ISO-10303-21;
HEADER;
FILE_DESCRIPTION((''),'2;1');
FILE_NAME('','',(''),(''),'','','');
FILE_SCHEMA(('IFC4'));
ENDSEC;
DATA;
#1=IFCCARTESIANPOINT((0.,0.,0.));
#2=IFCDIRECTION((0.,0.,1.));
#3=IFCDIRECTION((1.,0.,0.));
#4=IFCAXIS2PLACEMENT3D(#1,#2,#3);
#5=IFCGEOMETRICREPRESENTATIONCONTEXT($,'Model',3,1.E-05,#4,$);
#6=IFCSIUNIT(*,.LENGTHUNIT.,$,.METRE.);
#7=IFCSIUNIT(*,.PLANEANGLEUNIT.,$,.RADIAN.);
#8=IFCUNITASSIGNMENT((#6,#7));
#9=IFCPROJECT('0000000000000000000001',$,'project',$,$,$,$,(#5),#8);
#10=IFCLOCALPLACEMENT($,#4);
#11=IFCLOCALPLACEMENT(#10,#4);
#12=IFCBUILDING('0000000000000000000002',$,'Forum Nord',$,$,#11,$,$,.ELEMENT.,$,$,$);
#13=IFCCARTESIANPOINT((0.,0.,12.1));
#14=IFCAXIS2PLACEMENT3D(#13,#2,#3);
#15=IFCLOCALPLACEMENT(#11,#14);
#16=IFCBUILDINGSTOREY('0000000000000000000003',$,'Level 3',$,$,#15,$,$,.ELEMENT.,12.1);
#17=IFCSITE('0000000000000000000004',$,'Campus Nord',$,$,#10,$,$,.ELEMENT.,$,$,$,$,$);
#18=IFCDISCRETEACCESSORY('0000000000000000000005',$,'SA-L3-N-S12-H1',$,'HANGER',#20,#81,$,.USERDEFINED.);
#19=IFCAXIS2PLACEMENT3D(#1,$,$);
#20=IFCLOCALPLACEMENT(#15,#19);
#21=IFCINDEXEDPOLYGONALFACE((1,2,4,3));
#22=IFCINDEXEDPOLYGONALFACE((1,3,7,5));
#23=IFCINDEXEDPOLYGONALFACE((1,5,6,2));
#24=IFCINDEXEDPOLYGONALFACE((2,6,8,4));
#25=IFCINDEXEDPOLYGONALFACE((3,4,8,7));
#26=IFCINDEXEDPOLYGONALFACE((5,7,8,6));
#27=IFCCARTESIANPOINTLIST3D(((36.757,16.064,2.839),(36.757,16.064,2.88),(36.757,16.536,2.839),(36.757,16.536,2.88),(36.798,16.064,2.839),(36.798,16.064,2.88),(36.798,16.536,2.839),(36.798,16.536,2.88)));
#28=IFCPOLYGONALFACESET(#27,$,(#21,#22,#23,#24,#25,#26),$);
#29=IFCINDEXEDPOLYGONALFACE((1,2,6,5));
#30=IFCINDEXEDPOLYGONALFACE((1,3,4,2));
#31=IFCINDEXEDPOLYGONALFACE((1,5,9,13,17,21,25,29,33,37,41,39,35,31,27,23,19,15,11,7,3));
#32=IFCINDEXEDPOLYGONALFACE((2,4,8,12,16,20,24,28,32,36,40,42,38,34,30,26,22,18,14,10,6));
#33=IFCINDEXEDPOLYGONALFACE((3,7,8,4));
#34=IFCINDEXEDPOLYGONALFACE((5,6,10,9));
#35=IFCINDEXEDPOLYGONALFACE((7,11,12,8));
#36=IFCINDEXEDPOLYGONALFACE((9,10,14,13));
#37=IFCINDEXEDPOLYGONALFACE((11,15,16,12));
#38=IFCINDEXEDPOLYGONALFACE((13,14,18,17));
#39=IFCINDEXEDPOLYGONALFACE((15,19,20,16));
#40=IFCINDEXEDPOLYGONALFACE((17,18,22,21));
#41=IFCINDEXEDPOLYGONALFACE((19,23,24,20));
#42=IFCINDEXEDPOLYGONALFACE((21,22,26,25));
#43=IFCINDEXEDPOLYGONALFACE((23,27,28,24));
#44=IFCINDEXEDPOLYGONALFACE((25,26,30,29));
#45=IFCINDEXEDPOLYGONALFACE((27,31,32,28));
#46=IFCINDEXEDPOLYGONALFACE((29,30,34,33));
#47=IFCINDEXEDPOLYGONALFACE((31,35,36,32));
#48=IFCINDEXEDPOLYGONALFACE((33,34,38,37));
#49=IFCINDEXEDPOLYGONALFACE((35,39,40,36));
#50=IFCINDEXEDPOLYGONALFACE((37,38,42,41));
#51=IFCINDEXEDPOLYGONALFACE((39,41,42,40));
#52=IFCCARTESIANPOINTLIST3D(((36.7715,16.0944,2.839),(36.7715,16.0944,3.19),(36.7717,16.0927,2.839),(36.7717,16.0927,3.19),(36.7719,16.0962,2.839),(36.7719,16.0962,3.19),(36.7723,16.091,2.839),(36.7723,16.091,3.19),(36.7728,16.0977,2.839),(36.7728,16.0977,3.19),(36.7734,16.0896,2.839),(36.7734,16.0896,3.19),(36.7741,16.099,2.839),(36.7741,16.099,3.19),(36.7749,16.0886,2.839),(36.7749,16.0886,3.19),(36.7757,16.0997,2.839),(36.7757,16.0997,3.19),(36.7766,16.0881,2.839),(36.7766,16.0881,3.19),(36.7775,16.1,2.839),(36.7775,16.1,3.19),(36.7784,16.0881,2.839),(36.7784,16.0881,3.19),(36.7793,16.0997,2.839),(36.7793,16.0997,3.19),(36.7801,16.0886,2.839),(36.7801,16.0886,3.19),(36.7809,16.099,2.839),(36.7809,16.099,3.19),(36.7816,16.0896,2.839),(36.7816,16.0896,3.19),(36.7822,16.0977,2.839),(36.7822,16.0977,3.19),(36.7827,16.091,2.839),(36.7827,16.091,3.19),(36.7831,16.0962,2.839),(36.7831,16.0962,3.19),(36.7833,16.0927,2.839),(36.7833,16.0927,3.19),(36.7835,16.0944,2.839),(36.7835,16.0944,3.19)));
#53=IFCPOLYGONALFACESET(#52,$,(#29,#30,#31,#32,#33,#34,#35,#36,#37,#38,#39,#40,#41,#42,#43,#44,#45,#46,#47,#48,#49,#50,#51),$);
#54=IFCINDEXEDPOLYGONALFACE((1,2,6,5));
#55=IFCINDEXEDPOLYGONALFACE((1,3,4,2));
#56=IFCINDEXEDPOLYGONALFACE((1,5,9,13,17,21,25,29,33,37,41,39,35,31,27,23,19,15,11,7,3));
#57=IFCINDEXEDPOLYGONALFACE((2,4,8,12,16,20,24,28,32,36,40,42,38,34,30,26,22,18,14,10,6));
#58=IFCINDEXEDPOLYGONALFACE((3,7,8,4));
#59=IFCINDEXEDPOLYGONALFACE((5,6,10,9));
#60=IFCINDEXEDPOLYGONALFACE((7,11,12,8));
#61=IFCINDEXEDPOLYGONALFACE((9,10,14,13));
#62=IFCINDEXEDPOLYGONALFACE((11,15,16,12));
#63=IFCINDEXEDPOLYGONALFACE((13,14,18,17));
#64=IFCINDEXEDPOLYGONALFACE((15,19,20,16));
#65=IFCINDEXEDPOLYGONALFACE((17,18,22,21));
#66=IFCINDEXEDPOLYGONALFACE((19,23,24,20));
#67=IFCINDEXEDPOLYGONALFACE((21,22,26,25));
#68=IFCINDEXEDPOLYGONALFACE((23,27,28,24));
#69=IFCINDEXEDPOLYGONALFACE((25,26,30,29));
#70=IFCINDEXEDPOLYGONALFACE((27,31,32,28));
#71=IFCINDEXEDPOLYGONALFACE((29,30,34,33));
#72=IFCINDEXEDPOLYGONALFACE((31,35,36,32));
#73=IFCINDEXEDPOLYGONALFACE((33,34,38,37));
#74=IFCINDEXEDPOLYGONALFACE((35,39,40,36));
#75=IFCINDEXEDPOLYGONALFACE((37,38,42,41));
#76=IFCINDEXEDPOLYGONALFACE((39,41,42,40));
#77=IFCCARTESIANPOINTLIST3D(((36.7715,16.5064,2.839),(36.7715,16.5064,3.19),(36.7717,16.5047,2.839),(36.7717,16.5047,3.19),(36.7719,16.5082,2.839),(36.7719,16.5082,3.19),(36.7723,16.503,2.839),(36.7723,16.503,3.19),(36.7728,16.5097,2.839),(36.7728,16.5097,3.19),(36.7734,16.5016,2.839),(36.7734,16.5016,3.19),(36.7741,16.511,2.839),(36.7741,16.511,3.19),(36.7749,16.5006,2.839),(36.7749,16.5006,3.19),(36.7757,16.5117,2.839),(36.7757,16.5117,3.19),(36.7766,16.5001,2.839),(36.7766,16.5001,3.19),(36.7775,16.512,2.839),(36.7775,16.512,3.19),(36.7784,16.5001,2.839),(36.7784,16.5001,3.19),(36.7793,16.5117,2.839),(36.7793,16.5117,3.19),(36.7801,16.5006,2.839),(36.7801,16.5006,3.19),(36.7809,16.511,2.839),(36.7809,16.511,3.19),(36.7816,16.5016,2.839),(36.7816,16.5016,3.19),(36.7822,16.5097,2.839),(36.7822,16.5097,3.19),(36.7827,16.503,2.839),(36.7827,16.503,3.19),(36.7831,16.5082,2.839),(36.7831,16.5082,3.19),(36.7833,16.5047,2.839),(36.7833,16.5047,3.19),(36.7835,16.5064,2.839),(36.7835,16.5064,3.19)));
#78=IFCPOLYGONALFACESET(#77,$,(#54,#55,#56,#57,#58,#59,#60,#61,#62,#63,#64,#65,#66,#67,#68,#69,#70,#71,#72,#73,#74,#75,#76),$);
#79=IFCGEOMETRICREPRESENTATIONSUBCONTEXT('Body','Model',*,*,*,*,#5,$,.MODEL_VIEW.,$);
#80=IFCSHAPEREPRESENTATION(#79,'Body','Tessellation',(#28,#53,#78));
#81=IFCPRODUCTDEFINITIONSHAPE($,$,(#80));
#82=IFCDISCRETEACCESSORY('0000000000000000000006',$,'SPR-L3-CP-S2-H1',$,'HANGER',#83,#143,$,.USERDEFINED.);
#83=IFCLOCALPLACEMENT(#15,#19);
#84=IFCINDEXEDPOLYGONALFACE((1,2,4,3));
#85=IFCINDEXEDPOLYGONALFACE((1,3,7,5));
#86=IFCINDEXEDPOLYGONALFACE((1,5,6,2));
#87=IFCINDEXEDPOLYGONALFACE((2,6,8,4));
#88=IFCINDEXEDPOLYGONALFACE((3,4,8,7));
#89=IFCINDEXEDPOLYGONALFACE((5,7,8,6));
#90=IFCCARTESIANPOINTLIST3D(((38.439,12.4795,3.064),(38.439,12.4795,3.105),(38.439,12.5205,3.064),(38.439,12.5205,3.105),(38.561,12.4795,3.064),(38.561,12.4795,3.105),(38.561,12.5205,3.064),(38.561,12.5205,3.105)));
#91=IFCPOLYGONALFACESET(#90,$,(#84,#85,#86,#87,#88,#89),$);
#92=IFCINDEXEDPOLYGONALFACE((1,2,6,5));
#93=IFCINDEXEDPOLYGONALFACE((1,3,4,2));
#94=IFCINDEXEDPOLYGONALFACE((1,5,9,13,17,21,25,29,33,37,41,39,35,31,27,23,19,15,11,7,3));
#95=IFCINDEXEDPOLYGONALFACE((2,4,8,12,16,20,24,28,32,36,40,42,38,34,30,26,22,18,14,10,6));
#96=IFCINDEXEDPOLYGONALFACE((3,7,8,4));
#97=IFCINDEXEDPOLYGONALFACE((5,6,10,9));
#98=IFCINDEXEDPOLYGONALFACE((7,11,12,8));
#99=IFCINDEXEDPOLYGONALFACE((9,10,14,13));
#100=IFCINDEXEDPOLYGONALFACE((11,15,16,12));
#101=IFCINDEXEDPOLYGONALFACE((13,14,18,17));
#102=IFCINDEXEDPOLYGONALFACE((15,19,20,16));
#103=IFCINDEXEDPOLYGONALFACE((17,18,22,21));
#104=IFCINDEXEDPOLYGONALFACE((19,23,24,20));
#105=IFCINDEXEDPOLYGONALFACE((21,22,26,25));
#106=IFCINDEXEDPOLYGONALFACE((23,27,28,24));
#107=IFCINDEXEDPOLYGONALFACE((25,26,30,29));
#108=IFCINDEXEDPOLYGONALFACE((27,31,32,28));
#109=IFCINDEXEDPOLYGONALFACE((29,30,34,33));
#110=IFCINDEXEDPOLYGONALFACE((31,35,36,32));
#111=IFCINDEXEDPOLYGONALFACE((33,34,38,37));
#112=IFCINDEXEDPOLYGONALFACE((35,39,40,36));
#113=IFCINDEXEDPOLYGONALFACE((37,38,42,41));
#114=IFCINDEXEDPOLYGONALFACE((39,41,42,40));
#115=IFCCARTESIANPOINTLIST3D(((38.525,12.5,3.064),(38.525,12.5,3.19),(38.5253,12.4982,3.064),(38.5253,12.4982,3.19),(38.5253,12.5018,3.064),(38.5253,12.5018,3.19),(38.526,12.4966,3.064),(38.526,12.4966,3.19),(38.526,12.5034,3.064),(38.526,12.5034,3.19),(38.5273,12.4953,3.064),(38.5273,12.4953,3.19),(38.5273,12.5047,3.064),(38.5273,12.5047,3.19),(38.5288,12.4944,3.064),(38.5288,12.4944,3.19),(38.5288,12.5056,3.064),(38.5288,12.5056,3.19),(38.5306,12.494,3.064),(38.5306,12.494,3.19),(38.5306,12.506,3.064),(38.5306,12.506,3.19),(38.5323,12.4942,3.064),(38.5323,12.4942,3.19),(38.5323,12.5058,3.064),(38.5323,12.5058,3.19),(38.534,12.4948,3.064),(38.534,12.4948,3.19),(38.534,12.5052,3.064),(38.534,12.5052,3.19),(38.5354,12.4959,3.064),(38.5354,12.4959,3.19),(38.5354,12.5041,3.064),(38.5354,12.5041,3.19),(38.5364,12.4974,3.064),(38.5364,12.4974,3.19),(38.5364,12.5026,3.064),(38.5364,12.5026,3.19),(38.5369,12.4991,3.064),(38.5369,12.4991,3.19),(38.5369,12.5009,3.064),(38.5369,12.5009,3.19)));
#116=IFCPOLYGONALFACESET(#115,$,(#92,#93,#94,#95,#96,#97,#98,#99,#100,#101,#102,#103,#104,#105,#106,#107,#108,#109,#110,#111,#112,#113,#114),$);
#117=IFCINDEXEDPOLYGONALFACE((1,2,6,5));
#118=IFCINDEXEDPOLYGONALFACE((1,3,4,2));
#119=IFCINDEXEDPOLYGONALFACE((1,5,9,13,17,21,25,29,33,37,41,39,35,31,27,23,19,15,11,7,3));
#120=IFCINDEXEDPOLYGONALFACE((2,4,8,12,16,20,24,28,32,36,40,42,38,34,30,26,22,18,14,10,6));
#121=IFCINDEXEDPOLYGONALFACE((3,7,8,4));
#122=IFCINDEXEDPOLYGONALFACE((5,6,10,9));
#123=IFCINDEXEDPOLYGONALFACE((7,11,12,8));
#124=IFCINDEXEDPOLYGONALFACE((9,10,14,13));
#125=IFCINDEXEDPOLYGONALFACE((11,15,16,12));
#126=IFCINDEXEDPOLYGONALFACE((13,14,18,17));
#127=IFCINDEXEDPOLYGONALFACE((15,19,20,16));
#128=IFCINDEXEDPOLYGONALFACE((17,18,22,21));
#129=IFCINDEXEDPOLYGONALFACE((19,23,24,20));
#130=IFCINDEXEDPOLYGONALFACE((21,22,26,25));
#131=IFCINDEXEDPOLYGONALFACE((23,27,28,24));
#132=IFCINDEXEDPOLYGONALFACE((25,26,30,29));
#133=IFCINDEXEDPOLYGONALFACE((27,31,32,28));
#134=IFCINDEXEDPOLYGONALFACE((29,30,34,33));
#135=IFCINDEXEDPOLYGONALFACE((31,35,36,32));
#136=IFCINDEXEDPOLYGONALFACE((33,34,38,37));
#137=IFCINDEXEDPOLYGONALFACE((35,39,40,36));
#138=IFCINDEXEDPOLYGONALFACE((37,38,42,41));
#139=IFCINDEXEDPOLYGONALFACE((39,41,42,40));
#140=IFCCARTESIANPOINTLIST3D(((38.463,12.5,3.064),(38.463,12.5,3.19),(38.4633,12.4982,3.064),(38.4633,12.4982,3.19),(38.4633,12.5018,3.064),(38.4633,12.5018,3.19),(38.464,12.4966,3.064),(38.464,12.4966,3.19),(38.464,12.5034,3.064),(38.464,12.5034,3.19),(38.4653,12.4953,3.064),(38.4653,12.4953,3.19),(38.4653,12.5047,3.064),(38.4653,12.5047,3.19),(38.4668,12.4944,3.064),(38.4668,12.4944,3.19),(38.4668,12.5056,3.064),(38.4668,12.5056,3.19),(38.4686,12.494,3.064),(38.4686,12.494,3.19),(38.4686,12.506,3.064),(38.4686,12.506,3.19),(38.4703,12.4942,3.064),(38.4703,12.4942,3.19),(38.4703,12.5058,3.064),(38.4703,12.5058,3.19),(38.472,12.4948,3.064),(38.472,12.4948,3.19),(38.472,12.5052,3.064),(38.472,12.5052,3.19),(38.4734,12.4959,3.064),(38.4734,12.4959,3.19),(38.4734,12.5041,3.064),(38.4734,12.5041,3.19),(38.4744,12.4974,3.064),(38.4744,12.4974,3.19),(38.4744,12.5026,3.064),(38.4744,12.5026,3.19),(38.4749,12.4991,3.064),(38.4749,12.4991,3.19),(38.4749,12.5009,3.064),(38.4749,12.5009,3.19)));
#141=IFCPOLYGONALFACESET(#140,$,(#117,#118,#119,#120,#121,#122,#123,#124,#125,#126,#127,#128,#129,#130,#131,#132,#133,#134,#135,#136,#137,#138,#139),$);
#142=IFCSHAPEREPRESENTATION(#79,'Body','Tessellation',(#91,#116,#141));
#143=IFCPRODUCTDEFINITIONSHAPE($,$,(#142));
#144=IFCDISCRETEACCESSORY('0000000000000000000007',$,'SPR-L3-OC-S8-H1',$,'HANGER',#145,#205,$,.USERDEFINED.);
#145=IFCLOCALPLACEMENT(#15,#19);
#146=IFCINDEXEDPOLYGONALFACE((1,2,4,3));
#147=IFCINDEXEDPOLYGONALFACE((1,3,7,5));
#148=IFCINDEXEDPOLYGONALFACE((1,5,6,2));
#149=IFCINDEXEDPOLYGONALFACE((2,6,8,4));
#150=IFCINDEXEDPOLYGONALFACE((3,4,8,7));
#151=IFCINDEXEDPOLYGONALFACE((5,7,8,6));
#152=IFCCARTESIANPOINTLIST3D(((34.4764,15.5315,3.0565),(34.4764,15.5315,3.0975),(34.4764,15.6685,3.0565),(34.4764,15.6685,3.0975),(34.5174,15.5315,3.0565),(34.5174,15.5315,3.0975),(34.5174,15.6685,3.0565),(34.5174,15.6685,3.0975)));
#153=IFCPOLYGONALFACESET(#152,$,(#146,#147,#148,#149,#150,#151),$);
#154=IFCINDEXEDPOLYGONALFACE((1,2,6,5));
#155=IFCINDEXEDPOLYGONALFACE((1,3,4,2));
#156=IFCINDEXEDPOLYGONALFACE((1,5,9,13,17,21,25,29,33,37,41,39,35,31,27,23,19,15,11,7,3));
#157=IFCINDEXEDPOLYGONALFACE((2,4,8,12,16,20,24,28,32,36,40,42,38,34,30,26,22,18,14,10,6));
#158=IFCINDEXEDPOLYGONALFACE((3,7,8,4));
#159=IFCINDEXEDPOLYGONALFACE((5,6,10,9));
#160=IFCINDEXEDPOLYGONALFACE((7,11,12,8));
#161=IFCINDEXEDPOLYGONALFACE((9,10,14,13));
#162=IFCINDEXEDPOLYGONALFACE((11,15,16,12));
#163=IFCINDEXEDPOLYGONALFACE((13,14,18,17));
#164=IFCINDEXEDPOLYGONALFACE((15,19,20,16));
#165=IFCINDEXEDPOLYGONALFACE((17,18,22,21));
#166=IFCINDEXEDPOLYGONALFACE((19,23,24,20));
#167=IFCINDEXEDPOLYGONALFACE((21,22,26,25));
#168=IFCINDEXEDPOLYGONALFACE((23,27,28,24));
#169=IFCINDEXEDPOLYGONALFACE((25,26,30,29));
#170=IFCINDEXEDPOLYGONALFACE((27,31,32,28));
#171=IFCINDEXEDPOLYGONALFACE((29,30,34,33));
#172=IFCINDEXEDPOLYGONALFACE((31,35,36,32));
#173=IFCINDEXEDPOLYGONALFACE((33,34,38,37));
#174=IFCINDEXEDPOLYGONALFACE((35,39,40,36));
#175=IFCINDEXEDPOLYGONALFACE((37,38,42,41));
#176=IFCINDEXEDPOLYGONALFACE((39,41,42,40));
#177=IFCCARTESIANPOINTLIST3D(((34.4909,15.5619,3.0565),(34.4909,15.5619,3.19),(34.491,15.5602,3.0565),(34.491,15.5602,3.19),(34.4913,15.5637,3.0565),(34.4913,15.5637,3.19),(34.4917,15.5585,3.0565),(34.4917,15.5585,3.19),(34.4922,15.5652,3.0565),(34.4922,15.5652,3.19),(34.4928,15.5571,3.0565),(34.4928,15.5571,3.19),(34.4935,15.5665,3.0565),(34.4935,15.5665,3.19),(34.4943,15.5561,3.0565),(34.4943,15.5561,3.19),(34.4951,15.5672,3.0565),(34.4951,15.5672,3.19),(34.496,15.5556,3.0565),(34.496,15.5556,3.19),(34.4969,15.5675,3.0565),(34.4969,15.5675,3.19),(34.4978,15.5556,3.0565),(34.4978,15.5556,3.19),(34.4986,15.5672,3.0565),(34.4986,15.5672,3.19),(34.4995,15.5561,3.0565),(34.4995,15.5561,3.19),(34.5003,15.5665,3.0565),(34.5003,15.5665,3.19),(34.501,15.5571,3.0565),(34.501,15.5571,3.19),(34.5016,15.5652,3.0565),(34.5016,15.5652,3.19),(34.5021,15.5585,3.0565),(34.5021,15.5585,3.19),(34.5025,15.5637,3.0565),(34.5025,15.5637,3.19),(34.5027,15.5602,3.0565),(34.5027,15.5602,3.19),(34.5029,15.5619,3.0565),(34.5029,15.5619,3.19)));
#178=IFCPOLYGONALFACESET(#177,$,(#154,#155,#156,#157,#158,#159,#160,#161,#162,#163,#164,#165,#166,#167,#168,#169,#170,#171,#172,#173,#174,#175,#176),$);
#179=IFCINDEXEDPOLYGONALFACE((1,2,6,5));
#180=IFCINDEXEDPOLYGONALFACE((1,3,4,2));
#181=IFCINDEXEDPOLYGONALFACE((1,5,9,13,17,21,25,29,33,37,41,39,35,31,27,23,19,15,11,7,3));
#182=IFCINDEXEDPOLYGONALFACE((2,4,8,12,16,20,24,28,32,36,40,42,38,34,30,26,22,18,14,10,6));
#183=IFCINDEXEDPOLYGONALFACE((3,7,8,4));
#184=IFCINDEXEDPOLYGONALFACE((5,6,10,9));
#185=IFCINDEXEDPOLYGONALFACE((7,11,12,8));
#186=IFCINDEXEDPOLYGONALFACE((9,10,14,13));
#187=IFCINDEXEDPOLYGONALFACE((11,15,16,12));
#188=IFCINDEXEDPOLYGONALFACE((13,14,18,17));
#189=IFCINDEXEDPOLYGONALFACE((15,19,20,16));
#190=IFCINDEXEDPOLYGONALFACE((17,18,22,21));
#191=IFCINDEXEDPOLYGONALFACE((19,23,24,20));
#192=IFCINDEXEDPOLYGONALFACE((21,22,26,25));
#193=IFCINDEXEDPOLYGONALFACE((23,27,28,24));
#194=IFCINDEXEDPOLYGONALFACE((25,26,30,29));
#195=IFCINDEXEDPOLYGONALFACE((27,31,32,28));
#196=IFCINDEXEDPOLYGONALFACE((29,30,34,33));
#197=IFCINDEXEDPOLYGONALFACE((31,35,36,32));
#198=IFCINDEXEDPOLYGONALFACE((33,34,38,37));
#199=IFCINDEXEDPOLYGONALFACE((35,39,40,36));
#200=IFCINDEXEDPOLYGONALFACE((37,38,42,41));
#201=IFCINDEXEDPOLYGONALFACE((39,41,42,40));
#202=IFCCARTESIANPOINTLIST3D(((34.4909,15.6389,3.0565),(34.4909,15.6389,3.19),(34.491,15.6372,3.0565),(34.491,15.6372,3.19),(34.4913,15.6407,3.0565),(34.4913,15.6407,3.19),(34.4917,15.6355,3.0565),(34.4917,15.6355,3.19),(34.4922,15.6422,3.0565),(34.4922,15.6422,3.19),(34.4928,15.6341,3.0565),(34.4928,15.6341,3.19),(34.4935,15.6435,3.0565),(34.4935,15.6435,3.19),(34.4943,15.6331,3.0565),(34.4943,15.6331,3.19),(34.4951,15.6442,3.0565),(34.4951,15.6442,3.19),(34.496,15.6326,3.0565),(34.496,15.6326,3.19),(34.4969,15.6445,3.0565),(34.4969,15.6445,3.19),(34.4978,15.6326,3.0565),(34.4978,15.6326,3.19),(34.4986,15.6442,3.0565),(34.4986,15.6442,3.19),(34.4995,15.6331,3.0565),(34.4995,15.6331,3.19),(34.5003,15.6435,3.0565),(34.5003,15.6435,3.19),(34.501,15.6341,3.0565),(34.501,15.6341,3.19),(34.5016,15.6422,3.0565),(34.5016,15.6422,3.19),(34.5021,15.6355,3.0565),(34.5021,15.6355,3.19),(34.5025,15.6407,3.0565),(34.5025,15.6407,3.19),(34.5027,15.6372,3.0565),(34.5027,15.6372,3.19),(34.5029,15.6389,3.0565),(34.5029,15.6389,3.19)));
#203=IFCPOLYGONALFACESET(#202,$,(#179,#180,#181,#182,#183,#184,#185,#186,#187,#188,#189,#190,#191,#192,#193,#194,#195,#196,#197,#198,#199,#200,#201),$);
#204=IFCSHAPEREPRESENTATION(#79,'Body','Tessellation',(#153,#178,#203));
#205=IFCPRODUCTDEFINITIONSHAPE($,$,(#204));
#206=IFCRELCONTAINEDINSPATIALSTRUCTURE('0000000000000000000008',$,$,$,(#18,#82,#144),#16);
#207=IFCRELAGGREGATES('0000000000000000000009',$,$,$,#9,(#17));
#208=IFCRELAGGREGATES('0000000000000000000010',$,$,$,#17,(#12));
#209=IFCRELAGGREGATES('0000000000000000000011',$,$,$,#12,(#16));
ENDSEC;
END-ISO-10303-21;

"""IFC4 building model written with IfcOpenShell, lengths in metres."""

from ifc_helpers import new_model, si_unit, frame, frame_2d, origin_with_axes, origin_2d_with_axis, place, context, subcontext, project, spatial, rectangle, circle, extrude, element, save


model = new_model("IFC4")

# Units and contexts
model_context = context("Model", 3, precision=1e-05, world=origin_with_axes())
body_context = subcontext(model_context, "Body", "Model", "MODEL_VIEW")
ifc_project = project(units=[si_unit("LENGTHUNIT", "METRE"), si_unit("PLANEANGLEUNIT", "RADIAN")], contexts=[model_context])

# Site, building, storey
site_placement = place(None, origin_with_axes())
site = spatial("IfcSite", under=ifc_project, at=site_placement, Name="Campus Nord", CompositionType="ELEMENT")
building_placement = place(site_placement, origin_with_axes())
building = spatial("IfcBuilding", under=site, at=building_placement, Name="Forum Nord", CompositionType="ELEMENT")
storey_placement = place(building_placement, frame((0.0, 0.0, 12.1), z_axis=(0.0, 0.0, 1.0), x_axis=(1.0, 0.0, 0.0)))
storey = spatial("IfcBuildingStorey", under=building, at=storey_placement, Name="Level 3", CompositionType="ELEMENT", Elevation=12.1)

# Discrete accessories
for number, where, z_axis, x_axis, name in (
    (1, (36.7775, 16.3, 2.88), (0.0, 0.0, 1.0), (0.0, 1.0, 0.0), "SA-L3-N-S12-H1"),
):
    element("IfcDiscreteAccessory", number, at=place(storey_placement, frame(where, z_axis=z_axis, x_axis=x_axis)), inside=storey, Name=name, ObjectType="HANGER", PredefinedType="USERDEFINED", context=body_context, shape_type="SweptSolid", body=[
        extrude(rectangle(XDim=0.472, YDim=0.041, at=origin_2d_with_axis()), frame((0.0, 0.0, -0.041), z_axis=(0.0, 0.0, 1.0), x_axis=(1.0, 0.0, 0.0)), (0.0, 0.0, 1.0), 0.041),
        extrude(circle(Radius=0.006, at=frame_2d((-0.206, 0.0), x_axis=(1.0, 0.0))), frame((0.0, 0.0, -0.041), z_axis=(0.0, 0.0, 1.0), x_axis=(1.0, 0.0, 0.0)), (0.0, 0.0, 1.0), 0.351),
        extrude(circle(Radius=0.006, at=frame_2d((0.206, 0.0), x_axis=(1.0, 0.0))), frame((0.0, 0.0, -0.041), z_axis=(0.0, 0.0, 1.0), x_axis=(1.0, 0.0, 0.0)), (0.0, 0.0, 1.0), 0.351),
    ])
discrete_accessory_placement = place(storey_placement, frame((38.5, 12.5, 3.105), z_axis=(0.0, 0.0, 1.0), x_axis=(-1.0, 0.0, 0.0)))
element("IfcDiscreteAccessory", 2, at=discrete_accessory_placement, inside=storey, Name="SPR-L3-CP-S2-H1", ObjectType="HANGER", PredefinedType="USERDEFINED", context=body_context, shape_type="SweptSolid", body=[
    extrude(rectangle(XDim=0.122, YDim=0.041, at=origin_2d_with_axis()), frame((0.0, 0.0, -0.041), z_axis=(0.0, 0.0, 1.0), x_axis=(1.0, 0.0, 0.0)), (0.0, 0.0, 1.0), 0.041),
    extrude(circle(Radius=0.006, at=frame_2d((-0.031, 0.0), x_axis=(1.0, 0.0))), frame((0.0, 0.0, -0.041), z_axis=(0.0, 0.0, 1.0), x_axis=(1.0, 0.0, 0.0)), (0.0, 0.0, 1.0), 0.126),
    extrude(circle(Radius=0.006, at=frame_2d((0.031, 0.0), x_axis=(1.0, 0.0))), frame((0.0, 0.0, -0.041), z_axis=(0.0, 0.0, 1.0), x_axis=(1.0, 0.0, 0.0)), (0.0, 0.0, 1.0), 0.126),
])
for number, where, z_axis, x_axis, name in (
    (3, (34.4969, 15.6, 3.0975), (0.0, 0.0, 1.0), (0.0, 1.0, 0.0), "SPR-L3-OC-S8-H1"),
):
    element("IfcDiscreteAccessory", number, at=place(storey_placement, frame(where, z_axis=z_axis, x_axis=x_axis)), inside=storey, Name=name, ObjectType="HANGER", PredefinedType="USERDEFINED", context=body_context, shape_type="SweptSolid", body=[
        extrude(rectangle(XDim=0.137, YDim=0.041, at=origin_2d_with_axis()), frame((0.0, 0.0, -0.041), z_axis=(0.0, 0.0, 1.0), x_axis=(1.0, 0.0, 0.0)), (0.0, 0.0, 1.0), 0.041),
        extrude(circle(Radius=0.006, at=frame_2d((-0.0385, 0.0), x_axis=(1.0, 0.0))), frame((0.0, 0.0, -0.041), z_axis=(0.0, 0.0, 1.0), x_axis=(1.0, 0.0, 0.0)), (0.0, 0.0, 1.0), 0.1335),
        extrude(circle(Radius=0.006, at=frame_2d((0.0385, 0.0), x_axis=(1.0, 0.0))), frame((0.0, 0.0, -0.041), z_axis=(0.0, 0.0, 1.0), x_axis=(1.0, 0.0, 0.0)), (0.0, 0.0, 1.0), 0.1335),
    ])

save(model, "model.ifc")
